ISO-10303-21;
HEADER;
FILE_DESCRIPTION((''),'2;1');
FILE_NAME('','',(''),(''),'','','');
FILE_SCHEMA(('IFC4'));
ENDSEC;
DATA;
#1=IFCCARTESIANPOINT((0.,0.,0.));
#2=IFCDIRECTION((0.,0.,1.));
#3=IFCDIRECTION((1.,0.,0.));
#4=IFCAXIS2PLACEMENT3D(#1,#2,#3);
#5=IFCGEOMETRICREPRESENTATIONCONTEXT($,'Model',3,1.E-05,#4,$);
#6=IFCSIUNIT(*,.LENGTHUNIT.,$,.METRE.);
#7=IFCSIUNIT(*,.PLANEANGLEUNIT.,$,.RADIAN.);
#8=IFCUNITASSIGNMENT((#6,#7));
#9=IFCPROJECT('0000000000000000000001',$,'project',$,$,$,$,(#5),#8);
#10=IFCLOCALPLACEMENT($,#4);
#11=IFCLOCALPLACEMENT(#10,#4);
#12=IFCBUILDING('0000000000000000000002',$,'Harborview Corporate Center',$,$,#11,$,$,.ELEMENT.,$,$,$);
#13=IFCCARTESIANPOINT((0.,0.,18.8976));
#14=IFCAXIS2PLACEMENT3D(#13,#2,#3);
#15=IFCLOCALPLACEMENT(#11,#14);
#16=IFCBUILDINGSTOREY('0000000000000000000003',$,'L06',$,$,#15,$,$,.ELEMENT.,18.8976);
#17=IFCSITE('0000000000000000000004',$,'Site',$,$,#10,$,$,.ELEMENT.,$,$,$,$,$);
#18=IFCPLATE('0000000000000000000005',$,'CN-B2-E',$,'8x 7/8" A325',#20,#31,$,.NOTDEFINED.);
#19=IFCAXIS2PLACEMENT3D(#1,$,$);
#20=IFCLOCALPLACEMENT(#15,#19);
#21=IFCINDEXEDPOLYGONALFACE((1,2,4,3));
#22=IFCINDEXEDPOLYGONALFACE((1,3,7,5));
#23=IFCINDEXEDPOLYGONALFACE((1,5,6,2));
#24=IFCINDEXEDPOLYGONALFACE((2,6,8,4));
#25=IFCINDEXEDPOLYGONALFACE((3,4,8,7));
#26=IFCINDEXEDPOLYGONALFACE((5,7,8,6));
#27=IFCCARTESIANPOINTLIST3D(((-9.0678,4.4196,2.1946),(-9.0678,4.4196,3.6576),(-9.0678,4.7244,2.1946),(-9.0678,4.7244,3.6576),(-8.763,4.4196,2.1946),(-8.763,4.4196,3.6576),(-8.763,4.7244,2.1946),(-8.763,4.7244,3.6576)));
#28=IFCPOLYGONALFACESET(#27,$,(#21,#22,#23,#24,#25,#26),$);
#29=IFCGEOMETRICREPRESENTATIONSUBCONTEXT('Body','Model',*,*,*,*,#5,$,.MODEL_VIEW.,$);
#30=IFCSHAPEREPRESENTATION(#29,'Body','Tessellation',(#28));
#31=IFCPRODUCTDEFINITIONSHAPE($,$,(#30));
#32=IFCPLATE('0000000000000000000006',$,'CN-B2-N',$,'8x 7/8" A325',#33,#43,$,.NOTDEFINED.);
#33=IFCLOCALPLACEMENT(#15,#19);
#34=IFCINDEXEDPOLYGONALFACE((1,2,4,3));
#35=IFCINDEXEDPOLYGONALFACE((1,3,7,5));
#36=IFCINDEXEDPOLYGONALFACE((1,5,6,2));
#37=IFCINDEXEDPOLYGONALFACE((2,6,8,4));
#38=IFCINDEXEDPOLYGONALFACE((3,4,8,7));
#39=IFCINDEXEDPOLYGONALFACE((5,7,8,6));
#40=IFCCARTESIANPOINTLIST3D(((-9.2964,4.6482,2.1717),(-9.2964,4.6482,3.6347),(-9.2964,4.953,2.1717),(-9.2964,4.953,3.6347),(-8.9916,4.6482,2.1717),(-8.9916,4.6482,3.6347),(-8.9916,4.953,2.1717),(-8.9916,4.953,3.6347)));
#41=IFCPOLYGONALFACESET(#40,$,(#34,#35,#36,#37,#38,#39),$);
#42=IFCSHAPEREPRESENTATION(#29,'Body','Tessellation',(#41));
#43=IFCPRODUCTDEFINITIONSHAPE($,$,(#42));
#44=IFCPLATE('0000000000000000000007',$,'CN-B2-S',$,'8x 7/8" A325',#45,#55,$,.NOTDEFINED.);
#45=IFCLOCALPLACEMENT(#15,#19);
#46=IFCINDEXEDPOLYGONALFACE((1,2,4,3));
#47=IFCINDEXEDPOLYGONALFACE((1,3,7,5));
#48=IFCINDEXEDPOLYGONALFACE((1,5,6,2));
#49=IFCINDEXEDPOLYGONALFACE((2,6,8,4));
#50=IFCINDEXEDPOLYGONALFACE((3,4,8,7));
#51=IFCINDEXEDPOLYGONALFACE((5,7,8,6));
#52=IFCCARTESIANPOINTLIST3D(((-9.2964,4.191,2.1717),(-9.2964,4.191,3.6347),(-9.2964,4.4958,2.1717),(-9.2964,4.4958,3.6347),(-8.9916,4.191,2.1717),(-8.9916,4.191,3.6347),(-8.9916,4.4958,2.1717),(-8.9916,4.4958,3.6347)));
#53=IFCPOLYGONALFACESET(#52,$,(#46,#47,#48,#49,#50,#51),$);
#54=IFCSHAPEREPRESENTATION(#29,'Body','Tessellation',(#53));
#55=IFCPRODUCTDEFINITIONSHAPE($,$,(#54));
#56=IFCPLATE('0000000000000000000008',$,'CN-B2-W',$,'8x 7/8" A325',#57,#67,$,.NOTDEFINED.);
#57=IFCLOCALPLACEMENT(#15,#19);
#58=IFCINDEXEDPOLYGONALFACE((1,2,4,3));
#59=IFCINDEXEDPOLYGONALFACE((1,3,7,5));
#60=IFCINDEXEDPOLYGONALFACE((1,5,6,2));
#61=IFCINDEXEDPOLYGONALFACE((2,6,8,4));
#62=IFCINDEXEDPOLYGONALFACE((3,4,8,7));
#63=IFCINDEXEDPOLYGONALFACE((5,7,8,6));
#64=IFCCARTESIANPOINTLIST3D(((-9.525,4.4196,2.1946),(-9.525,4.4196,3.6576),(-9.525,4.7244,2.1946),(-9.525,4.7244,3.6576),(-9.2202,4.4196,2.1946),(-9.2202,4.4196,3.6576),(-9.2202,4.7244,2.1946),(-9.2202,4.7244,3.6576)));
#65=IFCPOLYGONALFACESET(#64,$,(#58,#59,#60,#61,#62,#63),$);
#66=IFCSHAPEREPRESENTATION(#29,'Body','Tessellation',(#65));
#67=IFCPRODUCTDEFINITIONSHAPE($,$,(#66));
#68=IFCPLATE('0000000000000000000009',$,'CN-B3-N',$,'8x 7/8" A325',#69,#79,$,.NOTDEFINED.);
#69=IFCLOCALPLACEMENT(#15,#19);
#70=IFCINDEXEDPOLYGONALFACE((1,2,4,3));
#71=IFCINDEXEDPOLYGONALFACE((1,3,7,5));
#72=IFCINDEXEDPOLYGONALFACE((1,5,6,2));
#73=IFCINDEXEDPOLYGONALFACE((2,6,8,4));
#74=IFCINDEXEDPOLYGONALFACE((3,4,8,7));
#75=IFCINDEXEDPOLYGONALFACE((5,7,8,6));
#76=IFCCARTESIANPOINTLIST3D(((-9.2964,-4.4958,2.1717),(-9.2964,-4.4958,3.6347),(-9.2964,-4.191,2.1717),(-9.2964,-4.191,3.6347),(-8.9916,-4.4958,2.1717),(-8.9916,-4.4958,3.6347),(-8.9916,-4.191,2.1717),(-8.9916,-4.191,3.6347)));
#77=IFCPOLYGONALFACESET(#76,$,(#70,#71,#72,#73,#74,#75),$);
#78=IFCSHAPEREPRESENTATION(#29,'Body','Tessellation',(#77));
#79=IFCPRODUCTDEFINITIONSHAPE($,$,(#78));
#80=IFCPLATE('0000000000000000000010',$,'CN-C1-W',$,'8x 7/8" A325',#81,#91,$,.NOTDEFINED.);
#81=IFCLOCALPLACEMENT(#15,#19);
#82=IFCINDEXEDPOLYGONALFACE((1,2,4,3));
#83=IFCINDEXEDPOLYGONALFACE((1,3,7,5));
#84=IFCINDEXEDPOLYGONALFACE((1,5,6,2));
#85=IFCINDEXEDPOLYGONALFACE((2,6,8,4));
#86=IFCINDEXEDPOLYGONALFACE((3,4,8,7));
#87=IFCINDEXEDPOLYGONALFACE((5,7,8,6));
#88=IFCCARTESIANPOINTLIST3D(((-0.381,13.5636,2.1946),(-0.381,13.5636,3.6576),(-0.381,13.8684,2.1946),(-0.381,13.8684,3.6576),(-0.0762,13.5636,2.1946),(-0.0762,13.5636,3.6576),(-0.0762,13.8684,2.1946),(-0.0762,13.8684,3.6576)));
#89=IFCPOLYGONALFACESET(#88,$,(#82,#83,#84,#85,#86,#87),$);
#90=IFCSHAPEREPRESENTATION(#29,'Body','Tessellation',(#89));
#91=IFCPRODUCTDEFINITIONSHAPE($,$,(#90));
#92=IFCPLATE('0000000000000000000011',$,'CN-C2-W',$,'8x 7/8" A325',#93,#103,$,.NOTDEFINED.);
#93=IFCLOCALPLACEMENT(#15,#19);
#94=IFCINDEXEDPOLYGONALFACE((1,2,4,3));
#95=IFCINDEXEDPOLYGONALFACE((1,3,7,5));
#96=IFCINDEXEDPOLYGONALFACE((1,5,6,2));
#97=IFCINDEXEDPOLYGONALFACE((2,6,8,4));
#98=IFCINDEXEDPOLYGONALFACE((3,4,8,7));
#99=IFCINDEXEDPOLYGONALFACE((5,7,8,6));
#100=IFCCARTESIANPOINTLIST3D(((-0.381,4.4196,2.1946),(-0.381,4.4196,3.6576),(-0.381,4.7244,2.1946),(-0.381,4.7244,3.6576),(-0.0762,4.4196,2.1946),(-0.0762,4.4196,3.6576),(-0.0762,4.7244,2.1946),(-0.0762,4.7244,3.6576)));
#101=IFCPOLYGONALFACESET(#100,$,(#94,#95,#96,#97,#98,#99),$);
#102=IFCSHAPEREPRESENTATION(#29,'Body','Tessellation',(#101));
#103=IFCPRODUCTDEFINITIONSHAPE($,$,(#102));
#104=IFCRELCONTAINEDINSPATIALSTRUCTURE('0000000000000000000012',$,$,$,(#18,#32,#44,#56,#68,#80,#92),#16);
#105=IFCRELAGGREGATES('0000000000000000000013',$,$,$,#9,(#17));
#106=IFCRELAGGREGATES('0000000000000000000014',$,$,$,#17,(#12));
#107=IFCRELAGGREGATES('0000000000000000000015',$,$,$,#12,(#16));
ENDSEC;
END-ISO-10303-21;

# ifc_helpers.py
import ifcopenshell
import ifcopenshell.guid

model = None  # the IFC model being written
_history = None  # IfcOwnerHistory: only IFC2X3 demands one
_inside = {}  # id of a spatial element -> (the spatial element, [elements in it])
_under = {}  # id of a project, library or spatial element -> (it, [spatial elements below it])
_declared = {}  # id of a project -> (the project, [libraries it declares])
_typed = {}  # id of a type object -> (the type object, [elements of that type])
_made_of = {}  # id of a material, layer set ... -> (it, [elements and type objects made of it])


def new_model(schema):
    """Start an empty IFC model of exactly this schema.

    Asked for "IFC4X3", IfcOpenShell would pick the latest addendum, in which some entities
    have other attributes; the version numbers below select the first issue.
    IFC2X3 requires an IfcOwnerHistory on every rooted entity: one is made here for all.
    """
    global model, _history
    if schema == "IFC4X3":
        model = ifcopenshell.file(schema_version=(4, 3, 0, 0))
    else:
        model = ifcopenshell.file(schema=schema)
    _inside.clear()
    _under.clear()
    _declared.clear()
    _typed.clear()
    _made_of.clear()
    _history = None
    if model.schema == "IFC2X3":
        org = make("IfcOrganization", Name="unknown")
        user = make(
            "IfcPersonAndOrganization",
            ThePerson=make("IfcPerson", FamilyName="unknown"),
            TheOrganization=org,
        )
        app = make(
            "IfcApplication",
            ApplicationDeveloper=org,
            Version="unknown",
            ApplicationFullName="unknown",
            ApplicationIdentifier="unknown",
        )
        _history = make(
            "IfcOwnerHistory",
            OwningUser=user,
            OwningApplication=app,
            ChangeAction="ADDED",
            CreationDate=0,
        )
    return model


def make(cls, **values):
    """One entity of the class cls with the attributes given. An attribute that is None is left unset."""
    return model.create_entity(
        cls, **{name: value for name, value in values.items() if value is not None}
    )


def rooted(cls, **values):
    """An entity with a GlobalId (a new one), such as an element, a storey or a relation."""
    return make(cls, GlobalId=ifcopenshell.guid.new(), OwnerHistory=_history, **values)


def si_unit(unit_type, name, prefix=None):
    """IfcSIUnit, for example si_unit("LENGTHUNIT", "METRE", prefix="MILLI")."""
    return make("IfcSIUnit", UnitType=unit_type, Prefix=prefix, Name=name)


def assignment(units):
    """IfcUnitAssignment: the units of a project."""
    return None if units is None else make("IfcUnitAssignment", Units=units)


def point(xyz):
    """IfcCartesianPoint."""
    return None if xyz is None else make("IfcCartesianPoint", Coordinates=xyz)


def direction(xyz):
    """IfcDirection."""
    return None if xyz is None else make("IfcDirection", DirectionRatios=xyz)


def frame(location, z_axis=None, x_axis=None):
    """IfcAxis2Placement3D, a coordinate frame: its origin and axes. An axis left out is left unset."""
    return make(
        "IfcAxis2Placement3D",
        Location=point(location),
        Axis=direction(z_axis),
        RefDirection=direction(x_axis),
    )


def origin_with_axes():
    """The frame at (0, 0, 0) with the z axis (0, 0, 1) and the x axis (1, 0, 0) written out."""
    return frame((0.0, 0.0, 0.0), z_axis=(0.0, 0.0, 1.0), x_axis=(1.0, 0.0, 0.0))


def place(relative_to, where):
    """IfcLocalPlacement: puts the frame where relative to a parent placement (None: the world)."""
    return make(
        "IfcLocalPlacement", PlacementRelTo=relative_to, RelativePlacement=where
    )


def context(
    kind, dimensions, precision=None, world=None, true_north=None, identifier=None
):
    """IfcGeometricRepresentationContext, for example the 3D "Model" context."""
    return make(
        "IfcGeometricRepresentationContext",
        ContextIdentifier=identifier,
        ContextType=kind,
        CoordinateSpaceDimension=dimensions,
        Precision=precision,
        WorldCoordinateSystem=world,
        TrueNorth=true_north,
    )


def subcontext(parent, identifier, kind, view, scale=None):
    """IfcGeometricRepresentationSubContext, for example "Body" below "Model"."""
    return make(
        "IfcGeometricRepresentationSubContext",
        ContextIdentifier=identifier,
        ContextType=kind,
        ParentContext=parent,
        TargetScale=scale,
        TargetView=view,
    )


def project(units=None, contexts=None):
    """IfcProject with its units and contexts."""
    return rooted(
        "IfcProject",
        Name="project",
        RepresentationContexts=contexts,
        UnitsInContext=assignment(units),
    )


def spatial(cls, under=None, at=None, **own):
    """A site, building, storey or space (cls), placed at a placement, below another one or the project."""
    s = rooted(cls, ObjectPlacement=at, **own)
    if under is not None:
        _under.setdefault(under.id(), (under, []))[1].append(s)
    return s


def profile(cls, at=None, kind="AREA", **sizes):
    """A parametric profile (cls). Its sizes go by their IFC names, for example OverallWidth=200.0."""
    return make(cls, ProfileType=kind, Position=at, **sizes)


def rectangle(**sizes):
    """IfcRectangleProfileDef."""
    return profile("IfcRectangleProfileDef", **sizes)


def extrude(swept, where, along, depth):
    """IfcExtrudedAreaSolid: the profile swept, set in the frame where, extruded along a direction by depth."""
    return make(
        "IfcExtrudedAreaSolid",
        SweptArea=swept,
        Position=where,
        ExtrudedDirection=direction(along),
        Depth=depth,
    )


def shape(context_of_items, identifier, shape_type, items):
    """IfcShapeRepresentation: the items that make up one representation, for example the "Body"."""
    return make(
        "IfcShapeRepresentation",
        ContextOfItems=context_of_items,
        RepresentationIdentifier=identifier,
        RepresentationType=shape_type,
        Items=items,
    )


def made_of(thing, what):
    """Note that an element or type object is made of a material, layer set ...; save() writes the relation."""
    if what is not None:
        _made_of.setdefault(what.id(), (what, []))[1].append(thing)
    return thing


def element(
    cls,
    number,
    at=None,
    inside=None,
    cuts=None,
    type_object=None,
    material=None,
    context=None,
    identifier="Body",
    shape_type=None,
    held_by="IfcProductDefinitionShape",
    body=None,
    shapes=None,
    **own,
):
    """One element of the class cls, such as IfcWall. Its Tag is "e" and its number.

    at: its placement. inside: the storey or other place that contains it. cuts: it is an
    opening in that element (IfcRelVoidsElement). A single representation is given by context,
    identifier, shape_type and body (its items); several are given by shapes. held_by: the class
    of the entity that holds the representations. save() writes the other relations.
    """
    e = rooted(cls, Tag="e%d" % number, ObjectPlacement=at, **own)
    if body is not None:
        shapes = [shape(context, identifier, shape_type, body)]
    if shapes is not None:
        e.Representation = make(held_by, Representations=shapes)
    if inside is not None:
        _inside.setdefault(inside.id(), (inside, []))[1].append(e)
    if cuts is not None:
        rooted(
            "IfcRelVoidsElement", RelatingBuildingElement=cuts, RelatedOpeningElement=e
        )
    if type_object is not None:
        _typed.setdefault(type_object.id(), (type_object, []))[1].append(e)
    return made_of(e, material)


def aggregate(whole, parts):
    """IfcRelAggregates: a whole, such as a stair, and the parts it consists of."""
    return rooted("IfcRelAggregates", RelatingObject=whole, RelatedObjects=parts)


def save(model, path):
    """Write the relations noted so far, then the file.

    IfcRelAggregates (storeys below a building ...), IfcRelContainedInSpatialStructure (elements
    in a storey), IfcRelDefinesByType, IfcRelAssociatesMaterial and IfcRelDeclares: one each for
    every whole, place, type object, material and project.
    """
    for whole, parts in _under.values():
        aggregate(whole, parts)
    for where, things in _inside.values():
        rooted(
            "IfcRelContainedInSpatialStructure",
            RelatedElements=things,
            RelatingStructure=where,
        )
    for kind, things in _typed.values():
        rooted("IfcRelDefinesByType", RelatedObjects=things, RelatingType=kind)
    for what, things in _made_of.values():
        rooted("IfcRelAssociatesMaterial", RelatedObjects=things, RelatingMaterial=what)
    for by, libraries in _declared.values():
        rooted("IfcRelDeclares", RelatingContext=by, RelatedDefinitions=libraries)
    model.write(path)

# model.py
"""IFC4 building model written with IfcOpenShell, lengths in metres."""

from ifc_helpers import new_model, si_unit, frame, origin_with_axes, place, context, subcontext, project, spatial, rectangle, extrude, element, save


model = new_model("IFC4")

# Units and contexts
model_context = context("Model", 3, precision=1e-05, world=origin_with_axes())
body_context = subcontext(model_context, "Body", "Model", "MODEL_VIEW")
ifc_project = project(units=[si_unit("LENGTHUNIT", "METRE"), si_unit("PLANEANGLEUNIT", "RADIAN")], contexts=[model_context])

# Site, building, storey
site_placement = place(None, origin_with_axes())
site = spatial("IfcSite", under=ifc_project, at=site_placement, Name="Site", CompositionType="ELEMENT")
building_placement = place(site_placement, origin_with_axes())
building = spatial("IfcBuilding", under=site, at=building_placement, Name="Harborview Corporate Center", CompositionType="ELEMENT")
storey_placement = place(building_placement, frame((0.0, 0.0, 18.8976), z_axis=(0.0, 0.0, 1.0), x_axis=(1.0, 0.0, 0.0)))
storey = spatial("IfcBuildingStorey", under=building, at=storey_placement, Name="L06", CompositionType="ELEMENT", Elevation=18.8976)

# Plates
for number, where, z_axis, x_axis, name in (
    (1, (-8.9154, 4.572, 2.1946), (0.0, 0.0, 1.0), (1.0, 0.0, 0.0), "CN-B2-E"),
    (2, (-9.144, 4.8006, 2.1717), (0.0, 0.0, 1.0), (1.0, 0.0, 0.0), "CN-B2-N"),
    (3, (-9.144, 4.3434, 2.1717), (0.0, 0.0, 1.0), (1.0, 0.0, 0.0), "CN-B2-S"),
    (4, (-9.3726, 4.572, 2.1946), (0.0, 0.0, 1.0), (1.0, 0.0, 0.0), "CN-B2-W"),
    (5, (-9.144, -4.3434, 2.1717), (0.0, 0.0, 1.0), (1.0, 0.0, 0.0), "CN-B3-N"),
):
    element("IfcPlate", number, at=place(storey_placement, frame(where, z_axis=z_axis, x_axis=x_axis)), inside=storey, Name=name, ObjectType="8x 7/8\" A325", PredefinedType="NOTDEFINED", context=body_context, shape_type="SweptSolid", body=[
        extrude(rectangle(XDim=0.3048, YDim=0.3048), origin_with_axes(), (0.0, 0.0, 1.0), 1.463),
    ])
for number, where, z_axis, x_axis, name in (
    (6, (-0.2286, 13.716, 2.1946), (0.0, 0.0, 1.0), (1.0, 0.0, 0.0), "CN-C1-W"),
    (7, (-0.2286, 4.572, 2.1946), (0.0, 0.0, 1.0), (1.0, 0.0, 0.0), "CN-C2-W"),
):
    element("IfcPlate", number, at=place(storey_placement, frame(where, z_axis=z_axis, x_axis=x_axis)), inside=storey, Name=name, ObjectType="8x 7/8\" A325", PredefinedType="NOTDEFINED", context=body_context, shape_type="SweptSolid", body=[
        extrude(rectangle(XDim=0.3048, YDim=0.3048), origin_with_axes(), (0.0, 0.0, 1.0), 1.463),
    ])

save(model, "model.ifc")
